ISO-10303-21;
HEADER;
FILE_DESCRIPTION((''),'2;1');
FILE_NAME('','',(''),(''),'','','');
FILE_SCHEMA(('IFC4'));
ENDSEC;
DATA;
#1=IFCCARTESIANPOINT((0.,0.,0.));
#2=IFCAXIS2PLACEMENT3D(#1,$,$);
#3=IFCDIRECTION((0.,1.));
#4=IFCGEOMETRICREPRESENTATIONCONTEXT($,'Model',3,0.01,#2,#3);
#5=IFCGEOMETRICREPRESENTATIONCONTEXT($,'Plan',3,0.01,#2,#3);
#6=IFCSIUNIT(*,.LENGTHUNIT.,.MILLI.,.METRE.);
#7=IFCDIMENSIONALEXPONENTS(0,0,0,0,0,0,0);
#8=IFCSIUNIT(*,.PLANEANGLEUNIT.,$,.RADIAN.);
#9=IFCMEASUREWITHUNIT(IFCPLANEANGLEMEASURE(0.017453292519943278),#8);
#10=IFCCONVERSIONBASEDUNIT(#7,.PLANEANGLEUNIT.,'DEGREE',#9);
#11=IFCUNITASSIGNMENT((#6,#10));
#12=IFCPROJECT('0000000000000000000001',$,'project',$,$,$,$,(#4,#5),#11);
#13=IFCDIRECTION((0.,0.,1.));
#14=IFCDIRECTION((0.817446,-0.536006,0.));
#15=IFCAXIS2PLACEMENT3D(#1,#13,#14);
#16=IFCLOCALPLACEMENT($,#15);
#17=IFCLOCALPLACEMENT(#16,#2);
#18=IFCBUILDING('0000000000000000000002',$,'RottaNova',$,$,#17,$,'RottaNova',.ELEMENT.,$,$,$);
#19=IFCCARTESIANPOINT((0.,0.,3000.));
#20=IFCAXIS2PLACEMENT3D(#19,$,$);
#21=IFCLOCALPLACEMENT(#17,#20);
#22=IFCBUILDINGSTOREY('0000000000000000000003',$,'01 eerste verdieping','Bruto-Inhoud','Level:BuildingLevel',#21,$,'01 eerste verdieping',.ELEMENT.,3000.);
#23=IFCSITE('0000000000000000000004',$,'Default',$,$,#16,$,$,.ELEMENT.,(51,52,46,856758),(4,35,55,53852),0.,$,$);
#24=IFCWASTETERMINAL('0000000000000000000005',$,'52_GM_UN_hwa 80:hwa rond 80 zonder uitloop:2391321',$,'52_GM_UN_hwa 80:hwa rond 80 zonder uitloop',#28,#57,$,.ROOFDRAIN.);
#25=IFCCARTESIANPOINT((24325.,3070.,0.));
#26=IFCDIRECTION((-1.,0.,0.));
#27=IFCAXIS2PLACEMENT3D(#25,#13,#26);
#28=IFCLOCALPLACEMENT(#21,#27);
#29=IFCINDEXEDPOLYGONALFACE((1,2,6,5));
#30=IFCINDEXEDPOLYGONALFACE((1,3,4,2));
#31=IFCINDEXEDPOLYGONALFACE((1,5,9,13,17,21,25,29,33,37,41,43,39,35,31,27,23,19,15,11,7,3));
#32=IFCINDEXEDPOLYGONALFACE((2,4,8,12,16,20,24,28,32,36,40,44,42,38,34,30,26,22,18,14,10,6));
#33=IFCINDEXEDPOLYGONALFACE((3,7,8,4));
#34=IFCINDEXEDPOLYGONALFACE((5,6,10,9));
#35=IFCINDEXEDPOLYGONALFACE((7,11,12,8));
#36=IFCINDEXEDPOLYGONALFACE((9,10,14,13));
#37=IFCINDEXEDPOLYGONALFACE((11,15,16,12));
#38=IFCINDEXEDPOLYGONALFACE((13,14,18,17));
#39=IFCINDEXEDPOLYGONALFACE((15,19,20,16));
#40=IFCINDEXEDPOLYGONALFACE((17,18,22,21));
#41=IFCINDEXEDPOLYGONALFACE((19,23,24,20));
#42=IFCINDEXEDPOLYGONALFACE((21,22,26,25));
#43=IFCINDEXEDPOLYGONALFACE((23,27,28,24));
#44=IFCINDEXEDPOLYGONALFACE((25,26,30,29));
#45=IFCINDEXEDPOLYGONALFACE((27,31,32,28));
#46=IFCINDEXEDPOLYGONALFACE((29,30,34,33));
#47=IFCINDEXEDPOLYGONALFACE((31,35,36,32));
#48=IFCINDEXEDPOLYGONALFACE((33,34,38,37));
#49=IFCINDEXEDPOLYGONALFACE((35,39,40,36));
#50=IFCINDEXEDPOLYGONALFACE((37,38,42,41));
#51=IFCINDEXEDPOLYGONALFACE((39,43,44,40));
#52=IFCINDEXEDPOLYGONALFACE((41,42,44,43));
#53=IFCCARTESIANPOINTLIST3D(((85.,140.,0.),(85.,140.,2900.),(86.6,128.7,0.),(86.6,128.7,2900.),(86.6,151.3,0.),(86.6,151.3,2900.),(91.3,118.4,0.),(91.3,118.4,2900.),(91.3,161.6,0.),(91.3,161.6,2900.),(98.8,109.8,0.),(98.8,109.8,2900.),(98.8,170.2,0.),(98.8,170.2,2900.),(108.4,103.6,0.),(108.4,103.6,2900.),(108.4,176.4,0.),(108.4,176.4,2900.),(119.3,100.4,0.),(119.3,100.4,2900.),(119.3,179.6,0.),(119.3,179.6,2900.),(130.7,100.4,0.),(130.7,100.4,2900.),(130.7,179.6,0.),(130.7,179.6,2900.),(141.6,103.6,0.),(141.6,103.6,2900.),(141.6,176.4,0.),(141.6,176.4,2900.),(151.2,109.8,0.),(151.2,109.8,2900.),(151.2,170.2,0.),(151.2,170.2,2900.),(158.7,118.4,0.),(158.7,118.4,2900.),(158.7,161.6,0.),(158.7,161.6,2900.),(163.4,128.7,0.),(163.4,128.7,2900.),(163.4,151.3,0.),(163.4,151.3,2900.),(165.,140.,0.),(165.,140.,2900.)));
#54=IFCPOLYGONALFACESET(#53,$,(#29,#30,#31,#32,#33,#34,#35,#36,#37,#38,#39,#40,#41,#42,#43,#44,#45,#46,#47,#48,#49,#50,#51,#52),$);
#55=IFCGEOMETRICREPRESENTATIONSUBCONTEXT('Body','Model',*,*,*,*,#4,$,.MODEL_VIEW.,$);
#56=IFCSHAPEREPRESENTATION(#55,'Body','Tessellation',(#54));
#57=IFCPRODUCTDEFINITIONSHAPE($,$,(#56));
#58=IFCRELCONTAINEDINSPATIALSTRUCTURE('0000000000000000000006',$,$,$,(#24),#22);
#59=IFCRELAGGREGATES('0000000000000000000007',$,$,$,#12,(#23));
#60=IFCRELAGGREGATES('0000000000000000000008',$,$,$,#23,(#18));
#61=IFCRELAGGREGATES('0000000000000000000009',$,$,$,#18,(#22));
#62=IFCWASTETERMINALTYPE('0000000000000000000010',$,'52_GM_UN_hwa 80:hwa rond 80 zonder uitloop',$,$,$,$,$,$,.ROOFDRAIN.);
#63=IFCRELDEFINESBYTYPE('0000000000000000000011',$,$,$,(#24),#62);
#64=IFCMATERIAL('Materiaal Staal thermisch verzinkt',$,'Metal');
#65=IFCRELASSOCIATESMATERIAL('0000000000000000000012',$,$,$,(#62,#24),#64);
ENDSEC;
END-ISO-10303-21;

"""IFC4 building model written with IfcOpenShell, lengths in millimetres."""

from ifc_helpers import new_model, entity, si_unit, converted_unit, direction, frame, origin, place, context, subcontext, project, spatial, arc, indexed_curve, outline, extrude, source, transform, mapped, material, type_object, type_shapes, element, save


model = new_model("IFC4")

# Units and contexts
model_context = context("Model", 3, precision=0.01, world=origin(), true_north=direction((0.0, 1.0)))
plan_context = context("Plan", 3, precision=0.01, world=origin(), true_north=direction((0.0, 1.0)))
body_context = subcontext(model_context, "Body", "Model", "MODEL_VIEW")
ifc_project = project(units=[si_unit("LENGTHUNIT", "METRE", prefix="MILLI"), converted_unit("PLANEANGLEUNIT", "DEGREE", entity("IfcPlaneAngleMeasure", 0.017453292519943278), si_unit("PLANEANGLEUNIT", "RADIAN"), dimensions=[0, 0, 0, 0, 0, 0, 0])], contexts=[model_context, plan_context])

# Site, building, storey
site_placement = place(None, frame((0.0, 0.0, 0.0), z_axis=(0.0, 0.0, 1.0), x_axis=(0.817446, -0.536006, 0.0)))
site = spatial("IfcSite", under=ifc_project, at=site_placement, Name="Default", CompositionType="ELEMENT", RefLatitude=(51, 52, 46, 856758), RefLongitude=(4, 35, 55, 53852), RefElevation=0.0)
building_placement = place(site_placement, origin())
building = spatial("IfcBuilding", under=site, at=building_placement, Name="RottaNova", LongName="RottaNova", CompositionType="ELEMENT")
storey_placement = place(building_placement, frame((0.0, 0.0, 3000.0)))
storey = spatial("IfcBuildingStorey", under=building, at=storey_placement, Name="01 eerste verdieping", Description="Bruto-Inhoud", ObjectType="Level:BuildingLevel", LongName="01 eerste verdieping", CompositionType="ELEMENT", Elevation=3000.0)

# Waste terminal
ifc_material_1 = material(Name="Materiaal Staal thermisch verzinkt", Category="Metal")
waste_terminal_type = type_object("IfcWasteTerminalType", Name="52_GM_UN_hwa 80:hwa rond 80 zonder uitloop", PredefinedType="ROOFDRAIN", material=ifc_material_1)
shared_shape_1 = source(origin(), body_context, "Body", "SweptSolid", [
    extrude(outline(indexed_curve([(-40.0, 0.0), (0.0, -40.0), (40.0, 0.0), (0.0, 40.0)], segments=[arc(1, 2, 3), arc(3, 4, 1)], self_intersect=False)), frame((125.0, 140.0, 0.0)), (0.0, 0.0, 1.0), 2900.0),
])
type_shapes(waste_terminal_type, [shared_shape_1])
waste_terminal_placement = place(storey_placement, frame((24325.0, 3070.0, 0.0), z_axis=(0.0, 0.0, 1.0), x_axis=(-1.0, 0.0, 0.0)))
element("IfcWasteTerminal", 1, at=waste_terminal_placement, inside=storey, type_object=waste_terminal_type, material=ifc_material_1, Name="52_GM_UN_hwa 80:hwa rond 80 zonder uitloop:2391321", ObjectType="52_GM_UN_hwa 80:hwa rond 80 zonder uitloop", PredefinedType="ROOFDRAIN", context=body_context, shape_type="MappedRepresentation", body=[
    mapped(shared_shape_1, transform((0.0, 0.0, 0.0), scale=1.0)),
])

save(model, "model.ifc")
